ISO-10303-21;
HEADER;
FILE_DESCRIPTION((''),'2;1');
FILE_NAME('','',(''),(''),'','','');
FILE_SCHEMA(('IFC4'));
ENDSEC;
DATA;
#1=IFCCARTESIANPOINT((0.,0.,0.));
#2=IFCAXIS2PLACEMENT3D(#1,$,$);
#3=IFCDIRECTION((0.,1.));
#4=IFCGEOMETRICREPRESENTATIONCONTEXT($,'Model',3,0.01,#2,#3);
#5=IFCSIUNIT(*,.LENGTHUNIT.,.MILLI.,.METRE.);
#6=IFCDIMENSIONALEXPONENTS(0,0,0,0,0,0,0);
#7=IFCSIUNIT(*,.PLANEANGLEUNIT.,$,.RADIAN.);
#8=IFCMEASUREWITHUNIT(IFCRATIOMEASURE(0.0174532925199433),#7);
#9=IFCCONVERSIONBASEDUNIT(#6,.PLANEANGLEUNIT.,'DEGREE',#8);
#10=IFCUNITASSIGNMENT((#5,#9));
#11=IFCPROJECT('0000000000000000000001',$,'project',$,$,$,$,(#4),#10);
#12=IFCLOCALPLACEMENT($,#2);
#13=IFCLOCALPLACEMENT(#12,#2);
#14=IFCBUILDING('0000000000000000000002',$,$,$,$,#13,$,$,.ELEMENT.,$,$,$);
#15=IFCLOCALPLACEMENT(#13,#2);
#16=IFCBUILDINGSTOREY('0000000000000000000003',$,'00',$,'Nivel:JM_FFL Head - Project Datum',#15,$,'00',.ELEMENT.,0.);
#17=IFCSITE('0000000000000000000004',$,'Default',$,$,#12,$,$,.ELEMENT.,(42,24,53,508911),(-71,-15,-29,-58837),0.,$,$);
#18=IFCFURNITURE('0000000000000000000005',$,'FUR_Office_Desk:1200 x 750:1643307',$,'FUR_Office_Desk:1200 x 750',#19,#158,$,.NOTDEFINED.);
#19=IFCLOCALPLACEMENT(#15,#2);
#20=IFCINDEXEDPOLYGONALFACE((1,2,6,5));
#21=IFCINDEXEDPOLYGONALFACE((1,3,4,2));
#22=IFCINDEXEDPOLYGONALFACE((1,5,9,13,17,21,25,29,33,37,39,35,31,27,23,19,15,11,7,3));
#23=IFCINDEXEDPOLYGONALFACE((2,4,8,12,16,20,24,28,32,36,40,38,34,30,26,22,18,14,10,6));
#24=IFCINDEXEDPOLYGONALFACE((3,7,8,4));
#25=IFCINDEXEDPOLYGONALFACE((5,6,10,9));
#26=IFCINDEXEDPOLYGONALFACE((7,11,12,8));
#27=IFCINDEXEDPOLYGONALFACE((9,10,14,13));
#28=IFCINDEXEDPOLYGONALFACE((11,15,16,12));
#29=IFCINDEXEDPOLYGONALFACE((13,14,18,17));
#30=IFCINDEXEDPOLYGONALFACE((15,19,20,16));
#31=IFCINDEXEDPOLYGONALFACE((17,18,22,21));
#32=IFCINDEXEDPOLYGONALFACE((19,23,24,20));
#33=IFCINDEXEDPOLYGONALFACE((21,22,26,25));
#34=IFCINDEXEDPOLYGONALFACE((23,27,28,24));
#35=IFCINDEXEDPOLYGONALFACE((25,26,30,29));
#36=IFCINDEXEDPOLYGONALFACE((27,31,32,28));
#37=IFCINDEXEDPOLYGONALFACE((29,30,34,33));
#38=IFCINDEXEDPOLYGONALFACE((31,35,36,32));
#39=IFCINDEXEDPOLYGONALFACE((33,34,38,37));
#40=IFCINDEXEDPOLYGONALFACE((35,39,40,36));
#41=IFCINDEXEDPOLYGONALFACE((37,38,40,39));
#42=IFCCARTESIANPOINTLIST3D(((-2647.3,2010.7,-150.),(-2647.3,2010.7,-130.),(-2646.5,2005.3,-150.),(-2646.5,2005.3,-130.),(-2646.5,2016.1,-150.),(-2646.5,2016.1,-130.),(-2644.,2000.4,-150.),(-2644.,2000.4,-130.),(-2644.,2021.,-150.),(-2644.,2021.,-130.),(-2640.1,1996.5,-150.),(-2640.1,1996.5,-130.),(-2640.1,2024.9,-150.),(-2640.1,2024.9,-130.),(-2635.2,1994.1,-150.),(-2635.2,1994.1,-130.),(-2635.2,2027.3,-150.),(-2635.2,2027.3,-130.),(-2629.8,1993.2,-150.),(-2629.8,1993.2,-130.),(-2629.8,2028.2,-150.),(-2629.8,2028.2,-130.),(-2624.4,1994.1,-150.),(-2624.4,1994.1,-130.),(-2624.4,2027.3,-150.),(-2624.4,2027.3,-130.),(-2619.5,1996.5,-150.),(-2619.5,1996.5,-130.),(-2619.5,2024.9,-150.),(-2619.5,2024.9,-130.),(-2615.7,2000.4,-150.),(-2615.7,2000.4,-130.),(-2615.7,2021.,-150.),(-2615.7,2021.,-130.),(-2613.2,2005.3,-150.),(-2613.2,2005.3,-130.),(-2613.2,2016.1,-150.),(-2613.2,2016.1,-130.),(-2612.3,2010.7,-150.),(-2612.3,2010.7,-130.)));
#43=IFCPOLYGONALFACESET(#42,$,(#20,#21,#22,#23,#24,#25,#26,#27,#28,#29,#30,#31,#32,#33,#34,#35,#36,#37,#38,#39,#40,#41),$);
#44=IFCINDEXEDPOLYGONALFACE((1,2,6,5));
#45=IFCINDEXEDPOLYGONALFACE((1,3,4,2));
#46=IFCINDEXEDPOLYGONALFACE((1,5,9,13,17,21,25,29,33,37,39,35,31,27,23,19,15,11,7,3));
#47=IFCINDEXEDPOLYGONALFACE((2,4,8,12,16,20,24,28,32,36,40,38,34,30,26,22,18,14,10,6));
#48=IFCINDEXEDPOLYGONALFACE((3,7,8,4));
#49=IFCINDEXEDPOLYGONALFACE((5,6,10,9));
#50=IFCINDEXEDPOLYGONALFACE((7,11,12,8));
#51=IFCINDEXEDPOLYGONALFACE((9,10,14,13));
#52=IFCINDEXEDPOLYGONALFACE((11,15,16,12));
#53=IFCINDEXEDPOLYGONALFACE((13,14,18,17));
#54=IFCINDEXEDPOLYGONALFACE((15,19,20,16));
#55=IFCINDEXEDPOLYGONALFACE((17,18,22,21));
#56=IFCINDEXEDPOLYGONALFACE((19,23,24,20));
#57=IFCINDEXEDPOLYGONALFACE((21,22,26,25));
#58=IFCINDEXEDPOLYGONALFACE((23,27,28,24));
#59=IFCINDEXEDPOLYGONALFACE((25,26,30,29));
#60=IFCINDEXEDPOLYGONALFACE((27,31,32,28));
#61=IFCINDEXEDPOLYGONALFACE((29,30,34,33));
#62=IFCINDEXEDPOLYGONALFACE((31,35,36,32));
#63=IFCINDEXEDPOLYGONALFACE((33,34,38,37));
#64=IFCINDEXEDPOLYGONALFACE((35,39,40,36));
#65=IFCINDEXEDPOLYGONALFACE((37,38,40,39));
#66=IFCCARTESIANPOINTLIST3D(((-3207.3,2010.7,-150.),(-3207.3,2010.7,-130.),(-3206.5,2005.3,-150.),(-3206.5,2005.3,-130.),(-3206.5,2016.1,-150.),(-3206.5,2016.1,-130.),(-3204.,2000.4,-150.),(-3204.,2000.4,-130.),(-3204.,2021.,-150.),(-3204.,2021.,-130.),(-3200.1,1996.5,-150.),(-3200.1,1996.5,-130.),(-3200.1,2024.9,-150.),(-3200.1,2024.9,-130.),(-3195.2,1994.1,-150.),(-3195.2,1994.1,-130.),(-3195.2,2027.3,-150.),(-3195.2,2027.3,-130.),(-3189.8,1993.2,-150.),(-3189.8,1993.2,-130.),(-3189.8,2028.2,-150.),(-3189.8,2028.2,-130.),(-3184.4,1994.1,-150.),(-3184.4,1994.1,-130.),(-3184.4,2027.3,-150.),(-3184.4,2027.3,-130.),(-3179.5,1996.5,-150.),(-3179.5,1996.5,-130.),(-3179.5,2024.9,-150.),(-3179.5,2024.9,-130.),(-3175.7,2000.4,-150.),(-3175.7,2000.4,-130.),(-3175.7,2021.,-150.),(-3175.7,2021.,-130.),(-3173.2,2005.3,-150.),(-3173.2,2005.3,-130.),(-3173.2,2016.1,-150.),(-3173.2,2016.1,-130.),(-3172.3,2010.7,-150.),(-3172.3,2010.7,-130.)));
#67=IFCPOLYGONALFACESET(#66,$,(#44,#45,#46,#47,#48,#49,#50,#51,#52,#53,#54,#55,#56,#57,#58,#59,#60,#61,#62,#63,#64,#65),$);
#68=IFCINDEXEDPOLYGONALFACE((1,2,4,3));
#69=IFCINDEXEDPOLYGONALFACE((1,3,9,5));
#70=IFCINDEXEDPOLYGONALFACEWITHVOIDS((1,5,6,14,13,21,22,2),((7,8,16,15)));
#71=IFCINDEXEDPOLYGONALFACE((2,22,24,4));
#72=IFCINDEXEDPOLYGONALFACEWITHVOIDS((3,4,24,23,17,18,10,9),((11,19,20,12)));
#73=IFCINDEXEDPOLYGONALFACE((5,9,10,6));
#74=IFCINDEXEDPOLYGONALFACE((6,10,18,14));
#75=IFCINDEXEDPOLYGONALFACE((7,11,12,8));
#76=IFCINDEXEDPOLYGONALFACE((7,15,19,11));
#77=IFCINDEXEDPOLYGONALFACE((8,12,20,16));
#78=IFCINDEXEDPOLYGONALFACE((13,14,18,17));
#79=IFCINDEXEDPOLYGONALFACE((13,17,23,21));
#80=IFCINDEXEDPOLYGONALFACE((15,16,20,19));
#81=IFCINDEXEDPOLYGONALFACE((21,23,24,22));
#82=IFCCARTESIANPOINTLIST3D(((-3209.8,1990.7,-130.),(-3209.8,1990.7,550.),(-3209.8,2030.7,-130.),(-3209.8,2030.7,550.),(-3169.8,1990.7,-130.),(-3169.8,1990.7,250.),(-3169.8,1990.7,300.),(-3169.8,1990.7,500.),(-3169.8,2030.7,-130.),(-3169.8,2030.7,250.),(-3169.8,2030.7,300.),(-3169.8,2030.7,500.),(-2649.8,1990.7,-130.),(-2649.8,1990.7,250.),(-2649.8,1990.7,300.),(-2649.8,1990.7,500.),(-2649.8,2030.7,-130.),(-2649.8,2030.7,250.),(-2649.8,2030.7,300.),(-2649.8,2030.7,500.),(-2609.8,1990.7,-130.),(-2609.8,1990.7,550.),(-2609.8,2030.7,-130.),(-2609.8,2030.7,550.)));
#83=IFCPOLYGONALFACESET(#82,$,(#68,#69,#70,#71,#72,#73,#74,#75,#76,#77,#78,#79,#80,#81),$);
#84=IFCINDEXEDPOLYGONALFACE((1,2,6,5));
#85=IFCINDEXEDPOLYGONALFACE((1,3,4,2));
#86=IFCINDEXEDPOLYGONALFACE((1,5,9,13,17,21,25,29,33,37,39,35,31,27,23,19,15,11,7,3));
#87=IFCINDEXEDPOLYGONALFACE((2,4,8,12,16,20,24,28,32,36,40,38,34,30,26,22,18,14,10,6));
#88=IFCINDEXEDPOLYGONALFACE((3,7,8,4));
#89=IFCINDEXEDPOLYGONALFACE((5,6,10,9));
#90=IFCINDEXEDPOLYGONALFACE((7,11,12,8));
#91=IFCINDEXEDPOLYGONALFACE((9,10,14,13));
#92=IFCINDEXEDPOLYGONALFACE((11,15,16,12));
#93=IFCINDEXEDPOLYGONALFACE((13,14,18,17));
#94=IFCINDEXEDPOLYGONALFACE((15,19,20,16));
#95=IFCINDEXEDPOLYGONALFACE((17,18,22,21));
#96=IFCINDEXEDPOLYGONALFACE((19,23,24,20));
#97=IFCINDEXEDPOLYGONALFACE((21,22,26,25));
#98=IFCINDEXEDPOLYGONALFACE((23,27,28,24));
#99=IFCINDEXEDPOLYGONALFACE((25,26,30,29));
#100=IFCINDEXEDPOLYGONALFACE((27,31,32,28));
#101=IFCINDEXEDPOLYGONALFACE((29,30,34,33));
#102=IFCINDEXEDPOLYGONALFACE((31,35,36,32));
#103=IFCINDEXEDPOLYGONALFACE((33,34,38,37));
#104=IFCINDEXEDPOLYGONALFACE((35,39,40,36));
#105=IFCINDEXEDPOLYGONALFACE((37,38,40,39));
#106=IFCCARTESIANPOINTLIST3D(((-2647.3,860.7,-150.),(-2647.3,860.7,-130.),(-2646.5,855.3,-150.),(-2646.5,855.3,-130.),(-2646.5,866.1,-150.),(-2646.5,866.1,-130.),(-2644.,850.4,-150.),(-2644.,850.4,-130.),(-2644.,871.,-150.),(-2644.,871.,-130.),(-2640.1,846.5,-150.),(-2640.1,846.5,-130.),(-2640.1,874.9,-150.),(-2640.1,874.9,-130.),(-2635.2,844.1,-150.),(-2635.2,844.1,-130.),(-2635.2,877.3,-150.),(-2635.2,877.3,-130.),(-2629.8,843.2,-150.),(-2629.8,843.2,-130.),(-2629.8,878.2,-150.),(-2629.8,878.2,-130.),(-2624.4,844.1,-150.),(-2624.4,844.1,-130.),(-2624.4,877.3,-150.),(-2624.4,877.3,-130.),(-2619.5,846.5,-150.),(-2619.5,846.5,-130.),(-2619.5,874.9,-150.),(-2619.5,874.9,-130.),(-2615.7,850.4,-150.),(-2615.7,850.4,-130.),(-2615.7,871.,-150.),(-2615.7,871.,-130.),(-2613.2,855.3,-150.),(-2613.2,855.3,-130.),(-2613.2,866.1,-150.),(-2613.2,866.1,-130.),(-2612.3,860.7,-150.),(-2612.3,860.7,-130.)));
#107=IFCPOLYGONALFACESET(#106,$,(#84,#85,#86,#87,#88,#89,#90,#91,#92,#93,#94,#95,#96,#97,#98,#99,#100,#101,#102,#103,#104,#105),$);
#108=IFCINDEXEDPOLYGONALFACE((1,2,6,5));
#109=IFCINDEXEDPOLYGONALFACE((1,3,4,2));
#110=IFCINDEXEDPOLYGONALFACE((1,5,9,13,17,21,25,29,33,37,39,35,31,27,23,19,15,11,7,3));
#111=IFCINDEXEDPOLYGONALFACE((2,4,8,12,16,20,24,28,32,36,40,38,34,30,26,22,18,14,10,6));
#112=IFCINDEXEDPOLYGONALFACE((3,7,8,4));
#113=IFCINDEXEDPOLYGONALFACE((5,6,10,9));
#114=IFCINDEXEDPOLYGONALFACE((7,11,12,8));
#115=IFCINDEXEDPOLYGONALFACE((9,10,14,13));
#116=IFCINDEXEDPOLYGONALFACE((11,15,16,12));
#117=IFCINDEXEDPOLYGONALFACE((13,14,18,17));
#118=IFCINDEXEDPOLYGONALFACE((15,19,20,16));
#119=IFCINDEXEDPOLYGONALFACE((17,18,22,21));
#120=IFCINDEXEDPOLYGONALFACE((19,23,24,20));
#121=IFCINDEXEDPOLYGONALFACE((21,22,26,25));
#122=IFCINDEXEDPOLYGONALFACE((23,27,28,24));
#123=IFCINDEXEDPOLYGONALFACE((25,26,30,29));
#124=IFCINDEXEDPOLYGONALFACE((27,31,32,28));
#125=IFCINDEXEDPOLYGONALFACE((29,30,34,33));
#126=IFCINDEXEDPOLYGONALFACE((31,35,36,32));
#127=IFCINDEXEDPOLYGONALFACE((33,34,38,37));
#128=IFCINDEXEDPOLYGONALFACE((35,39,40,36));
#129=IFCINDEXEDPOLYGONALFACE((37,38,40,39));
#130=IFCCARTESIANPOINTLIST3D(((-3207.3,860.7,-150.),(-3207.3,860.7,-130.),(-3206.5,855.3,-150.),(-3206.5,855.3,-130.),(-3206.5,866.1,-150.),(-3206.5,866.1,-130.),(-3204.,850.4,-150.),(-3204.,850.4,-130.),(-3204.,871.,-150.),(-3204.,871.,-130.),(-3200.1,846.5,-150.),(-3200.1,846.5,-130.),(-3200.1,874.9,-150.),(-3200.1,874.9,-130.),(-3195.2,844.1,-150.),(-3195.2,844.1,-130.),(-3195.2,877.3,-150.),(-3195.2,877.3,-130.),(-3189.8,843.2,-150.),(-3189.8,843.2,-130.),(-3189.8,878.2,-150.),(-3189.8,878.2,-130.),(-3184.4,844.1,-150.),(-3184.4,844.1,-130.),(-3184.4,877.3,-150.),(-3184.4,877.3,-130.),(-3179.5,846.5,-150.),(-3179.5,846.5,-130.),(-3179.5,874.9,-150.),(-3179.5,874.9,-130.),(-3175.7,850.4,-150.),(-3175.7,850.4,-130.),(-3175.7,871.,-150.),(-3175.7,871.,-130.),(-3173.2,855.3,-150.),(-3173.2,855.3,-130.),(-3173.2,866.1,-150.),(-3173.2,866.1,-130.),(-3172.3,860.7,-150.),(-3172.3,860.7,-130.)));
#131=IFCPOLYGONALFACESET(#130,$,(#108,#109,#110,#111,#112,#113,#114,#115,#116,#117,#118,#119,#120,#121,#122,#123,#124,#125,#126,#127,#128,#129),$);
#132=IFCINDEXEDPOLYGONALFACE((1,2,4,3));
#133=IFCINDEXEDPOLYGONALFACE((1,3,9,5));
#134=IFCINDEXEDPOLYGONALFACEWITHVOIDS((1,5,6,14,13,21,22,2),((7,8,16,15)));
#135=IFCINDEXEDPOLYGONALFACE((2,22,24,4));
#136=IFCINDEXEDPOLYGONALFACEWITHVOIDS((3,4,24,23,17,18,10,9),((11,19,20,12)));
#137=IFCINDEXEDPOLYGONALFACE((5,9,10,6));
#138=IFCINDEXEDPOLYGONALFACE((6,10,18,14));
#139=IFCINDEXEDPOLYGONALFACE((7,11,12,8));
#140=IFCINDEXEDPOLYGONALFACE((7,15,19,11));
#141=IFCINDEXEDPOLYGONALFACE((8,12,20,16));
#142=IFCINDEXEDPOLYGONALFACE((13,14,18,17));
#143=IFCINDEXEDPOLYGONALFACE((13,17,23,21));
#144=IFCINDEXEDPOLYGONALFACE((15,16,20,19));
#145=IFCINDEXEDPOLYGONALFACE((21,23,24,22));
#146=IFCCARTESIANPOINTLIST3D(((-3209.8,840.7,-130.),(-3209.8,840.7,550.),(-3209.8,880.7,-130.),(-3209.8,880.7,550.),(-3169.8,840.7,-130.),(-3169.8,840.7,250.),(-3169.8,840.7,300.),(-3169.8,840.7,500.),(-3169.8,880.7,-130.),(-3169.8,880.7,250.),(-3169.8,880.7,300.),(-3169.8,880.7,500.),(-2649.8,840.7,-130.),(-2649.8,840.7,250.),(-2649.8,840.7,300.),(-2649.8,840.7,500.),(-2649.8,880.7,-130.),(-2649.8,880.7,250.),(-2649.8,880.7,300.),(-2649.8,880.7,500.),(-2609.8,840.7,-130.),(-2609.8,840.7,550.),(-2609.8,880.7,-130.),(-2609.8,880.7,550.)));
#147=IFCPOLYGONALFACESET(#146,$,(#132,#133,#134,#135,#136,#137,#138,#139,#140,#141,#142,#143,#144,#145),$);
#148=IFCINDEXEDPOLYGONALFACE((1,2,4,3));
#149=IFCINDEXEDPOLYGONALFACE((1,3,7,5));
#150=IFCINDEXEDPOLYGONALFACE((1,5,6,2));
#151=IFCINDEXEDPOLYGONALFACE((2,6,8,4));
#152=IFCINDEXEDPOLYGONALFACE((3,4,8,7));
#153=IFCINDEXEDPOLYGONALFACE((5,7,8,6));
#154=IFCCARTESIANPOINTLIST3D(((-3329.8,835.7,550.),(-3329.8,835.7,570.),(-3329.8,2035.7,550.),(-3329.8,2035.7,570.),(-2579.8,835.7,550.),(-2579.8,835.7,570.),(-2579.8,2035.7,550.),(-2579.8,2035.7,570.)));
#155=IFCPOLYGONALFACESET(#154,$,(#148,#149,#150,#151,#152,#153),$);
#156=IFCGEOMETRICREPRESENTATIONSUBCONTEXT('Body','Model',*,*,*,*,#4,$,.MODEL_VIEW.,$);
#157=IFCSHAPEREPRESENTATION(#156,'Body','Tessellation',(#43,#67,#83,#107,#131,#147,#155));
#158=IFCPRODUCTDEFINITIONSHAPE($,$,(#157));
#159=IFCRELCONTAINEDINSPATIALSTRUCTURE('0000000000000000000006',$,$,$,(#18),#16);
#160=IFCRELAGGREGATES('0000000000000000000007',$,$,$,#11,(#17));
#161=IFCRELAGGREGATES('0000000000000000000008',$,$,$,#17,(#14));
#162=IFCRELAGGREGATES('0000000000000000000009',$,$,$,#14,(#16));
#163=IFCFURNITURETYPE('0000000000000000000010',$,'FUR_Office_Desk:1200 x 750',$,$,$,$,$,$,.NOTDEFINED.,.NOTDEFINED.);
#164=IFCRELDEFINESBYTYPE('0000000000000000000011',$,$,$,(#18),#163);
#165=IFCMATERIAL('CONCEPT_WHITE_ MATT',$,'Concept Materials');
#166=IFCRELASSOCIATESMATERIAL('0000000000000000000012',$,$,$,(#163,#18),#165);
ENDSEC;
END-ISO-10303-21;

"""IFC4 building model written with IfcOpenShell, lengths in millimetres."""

from ifc_helpers import new_model, entity, si_unit, converted_unit, direction, frame, origin, place, context, subcontext, project, spatial, indexed_curve, outline, extrude, source, transform, mapped, material, type_object, type_shapes, element, save


model = new_model("IFC4")

# Units and contexts
model_context = context("Model", 3, precision=0.01, world=origin(), true_north=direction((0.0, 1.0)))
body_context = subcontext(model_context, "Body", "Model", "MODEL_VIEW")
ifc_project = project(units=[si_unit("LENGTHUNIT", "METRE", prefix="MILLI"), converted_unit("PLANEANGLEUNIT", "DEGREE", entity("IfcRatioMeasure", 0.0174532925199433), si_unit("PLANEANGLEUNIT", "RADIAN"), dimensions=[0, 0, 0, 0, 0, 0, 0])], contexts=[model_context])

# Site, building, storey
site_placement = place(None, origin())
site = spatial("IfcSite", under=ifc_project, at=site_placement, Name="Default", CompositionType="ELEMENT", RefLatitude=(42, 24, 53, 508911), RefLongitude=(-71, -15, -29, -58837), RefElevation=0.0)
building_placement = place(site_placement, origin())
building = spatial("IfcBuilding", under=site, at=building_placement, CompositionType="ELEMENT")
storey_placement = place(building_placement, origin())
storey = spatial("IfcBuildingStorey", under=building, at=storey_placement, Name="00", ObjectType="Nivel:JM_FFL Head - Project Datum", LongName="00", CompositionType="ELEMENT", Elevation=0.0)

# Shared definitions
ifc_material_1 = material(Name="CONCEPT_WHITE_ MATT", Category="Concept Materials")

# Furniture
furniture_type_1 = type_object("IfcFurnitureType", Name="FUR_Office_Desk:1200 x 750", AssemblyPlace="NOTDEFINED", PredefinedType="NOTDEFINED", material=ifc_material_1)
shared_shape_1 = source(origin(), body_context, "Body", "SweptSolid", [
    extrude(outline(indexed_curve([(17.5, 0.0), (16.6, 5.4), (14.2, 10.3), (10.3, 14.2), (5.4, 16.6), (0.0, 17.5), (-5.4, 16.6), (-10.3, 14.2), (-14.2, 10.3), (-16.6, 5.4), (-17.5, 0.0), (-16.6, -5.4), (-14.2, -10.3), (-10.3, -14.2), (-5.4, -16.6), (0.0, -17.5), (5.4, -16.6), (10.3, -14.2), (14.2, -10.3), (16.6, -5.4), (17.5, 0.0)], self_intersect=False)), frame((-530.3, 700.0, 0.0)), (0.0, 0.0, 1.0), 20.0),
    extrude(outline(indexed_curve([(17.5, 0.0), (16.6, 5.4), (14.2, 10.3), (10.3, 14.2), (5.4, 16.6), (0.0, 17.5), (-5.4, 16.6), (-10.3, 14.2), (-14.2, 10.3), (-16.6, 5.4), (-17.5, 0.0), (-16.6, -5.4), (-14.2, -10.3), (-10.3, -14.2), (-5.4, -16.6), (0.0, -17.5), (5.4, -16.6), (10.3, -14.2), (14.2, -10.3), (16.6, -5.4), (17.5, 0.0)], self_intersect=False)), frame((-530.3, 140.0, 0.0)), (0.0, 0.0, 1.0), 20.0),
    extrude(outline(indexed_curve([(-300.0, -265.0), (-260.0, -265.0), (-260.0, 115.0), (260.0, 115.0), (260.0, -265.0), (300.0, -265.0), (300.0, 415.0), (-300.0, 415.0), (-300.0, -265.0)], self_intersect=False), holes=[indexed_curve([(260.0, 165.0), (-260.0, 165.0), (-260.0, 365.0), (260.0, 365.0), (260.0, 165.0)], self_intersect=False)]), frame((-550.3, 420.0, 285.0), z_axis=(1.0, 0.0, 0.0), x_axis=(0.0, 1.0, 0.0)), (0.0, 0.0, 1.0), 40.0),
    extrude(outline(indexed_curve([(17.5, 0.0), (16.6, 5.4), (14.2, 10.3), (10.3, 14.2), (5.4, 16.6), (0.0, 17.5), (-5.4, 16.6), (-10.3, 14.2), (-14.2, 10.3), (-16.6, 5.4), (-17.5, 0.0), (-16.6, -5.4), (-14.2, -10.3), (-10.3, -14.2), (-5.4, -16.6), (0.0, -17.5), (5.4, -16.6), (10.3, -14.2), (14.2, -10.3), (16.6, -5.4), (17.5, 0.0)], self_intersect=False)), frame((619.7, 700.0, 0.0)), (0.0, 0.0, 1.0), 20.0),
    extrude(outline(indexed_curve([(17.5, 0.0), (16.6, 5.4), (14.2, 10.3), (10.3, 14.2), (5.4, 16.6), (0.0, 17.5), (-5.4, 16.6), (-10.3, 14.2), (-14.2, 10.3), (-16.6, 5.4), (-17.5, 0.0), (-16.6, -5.4), (-14.2, -10.3), (-10.3, -14.2), (-5.4, -16.6), (0.0, -17.5), (5.4, -16.6), (10.3, -14.2), (14.2, -10.3), (16.6, -5.4), (17.5, 0.0)], self_intersect=False)), frame((619.7, 140.0, 0.0)), (0.0, 0.0, 1.0), 20.0),
    extrude(outline(indexed_curve([(-300.0, -265.0), (-260.0, -265.0), (-260.0, 115.0), (260.0, 115.0), (260.0, -265.0), (300.0, -265.0), (300.0, 415.0), (-300.0, 415.0), (-300.0, -265.0)], self_intersect=False), holes=[indexed_curve([(260.0, 165.0), (-260.0, 165.0), (-260.0, 365.0), (260.0, 365.0), (260.0, 165.0)], self_intersect=False)]), frame((599.7, 420.0, 285.0), z_axis=(1.0, 0.0, 0.0), x_axis=(0.0, 1.0, 0.0)), (0.0, 0.0, 1.0), 40.0),
    extrude(outline(indexed_curve([(-375.0, -600.0), (375.0, -600.0), (375.0, 600.0), (-375.0, 600.0), (-375.0, -600.0)], self_intersect=False)), frame((44.7, 375.0, 700.0), z_axis=(0.0, 0.0, 1.0), x_axis=(0.0, 1.0, 0.0)), (0.0, 0.0, 1.0), 20.0),
])
type_shapes(furniture_type_1, [shared_shape_1])
furniture_1_placement = place(storey_placement, frame((-3329.8, 1480.4, -150.0), z_axis=(0.0, 0.0, 1.0), x_axis=(0.0, -1.0, 0.0)))
element("IfcFurniture", 1, at=furniture_1_placement, inside=storey, type_object=furniture_type_1, material=ifc_material_1, Name="FUR_Office_Desk:1200 x 750:1643307", ObjectType="FUR_Office_Desk:1200 x 750", PredefinedType="NOTDEFINED", context=body_context, shape_type="MappedRepresentation", body=[
    mapped(shared_shape_1, transform((0.0, 0.0, 0.0), scale=1.0)),
])

save(model, "model.ifc")
